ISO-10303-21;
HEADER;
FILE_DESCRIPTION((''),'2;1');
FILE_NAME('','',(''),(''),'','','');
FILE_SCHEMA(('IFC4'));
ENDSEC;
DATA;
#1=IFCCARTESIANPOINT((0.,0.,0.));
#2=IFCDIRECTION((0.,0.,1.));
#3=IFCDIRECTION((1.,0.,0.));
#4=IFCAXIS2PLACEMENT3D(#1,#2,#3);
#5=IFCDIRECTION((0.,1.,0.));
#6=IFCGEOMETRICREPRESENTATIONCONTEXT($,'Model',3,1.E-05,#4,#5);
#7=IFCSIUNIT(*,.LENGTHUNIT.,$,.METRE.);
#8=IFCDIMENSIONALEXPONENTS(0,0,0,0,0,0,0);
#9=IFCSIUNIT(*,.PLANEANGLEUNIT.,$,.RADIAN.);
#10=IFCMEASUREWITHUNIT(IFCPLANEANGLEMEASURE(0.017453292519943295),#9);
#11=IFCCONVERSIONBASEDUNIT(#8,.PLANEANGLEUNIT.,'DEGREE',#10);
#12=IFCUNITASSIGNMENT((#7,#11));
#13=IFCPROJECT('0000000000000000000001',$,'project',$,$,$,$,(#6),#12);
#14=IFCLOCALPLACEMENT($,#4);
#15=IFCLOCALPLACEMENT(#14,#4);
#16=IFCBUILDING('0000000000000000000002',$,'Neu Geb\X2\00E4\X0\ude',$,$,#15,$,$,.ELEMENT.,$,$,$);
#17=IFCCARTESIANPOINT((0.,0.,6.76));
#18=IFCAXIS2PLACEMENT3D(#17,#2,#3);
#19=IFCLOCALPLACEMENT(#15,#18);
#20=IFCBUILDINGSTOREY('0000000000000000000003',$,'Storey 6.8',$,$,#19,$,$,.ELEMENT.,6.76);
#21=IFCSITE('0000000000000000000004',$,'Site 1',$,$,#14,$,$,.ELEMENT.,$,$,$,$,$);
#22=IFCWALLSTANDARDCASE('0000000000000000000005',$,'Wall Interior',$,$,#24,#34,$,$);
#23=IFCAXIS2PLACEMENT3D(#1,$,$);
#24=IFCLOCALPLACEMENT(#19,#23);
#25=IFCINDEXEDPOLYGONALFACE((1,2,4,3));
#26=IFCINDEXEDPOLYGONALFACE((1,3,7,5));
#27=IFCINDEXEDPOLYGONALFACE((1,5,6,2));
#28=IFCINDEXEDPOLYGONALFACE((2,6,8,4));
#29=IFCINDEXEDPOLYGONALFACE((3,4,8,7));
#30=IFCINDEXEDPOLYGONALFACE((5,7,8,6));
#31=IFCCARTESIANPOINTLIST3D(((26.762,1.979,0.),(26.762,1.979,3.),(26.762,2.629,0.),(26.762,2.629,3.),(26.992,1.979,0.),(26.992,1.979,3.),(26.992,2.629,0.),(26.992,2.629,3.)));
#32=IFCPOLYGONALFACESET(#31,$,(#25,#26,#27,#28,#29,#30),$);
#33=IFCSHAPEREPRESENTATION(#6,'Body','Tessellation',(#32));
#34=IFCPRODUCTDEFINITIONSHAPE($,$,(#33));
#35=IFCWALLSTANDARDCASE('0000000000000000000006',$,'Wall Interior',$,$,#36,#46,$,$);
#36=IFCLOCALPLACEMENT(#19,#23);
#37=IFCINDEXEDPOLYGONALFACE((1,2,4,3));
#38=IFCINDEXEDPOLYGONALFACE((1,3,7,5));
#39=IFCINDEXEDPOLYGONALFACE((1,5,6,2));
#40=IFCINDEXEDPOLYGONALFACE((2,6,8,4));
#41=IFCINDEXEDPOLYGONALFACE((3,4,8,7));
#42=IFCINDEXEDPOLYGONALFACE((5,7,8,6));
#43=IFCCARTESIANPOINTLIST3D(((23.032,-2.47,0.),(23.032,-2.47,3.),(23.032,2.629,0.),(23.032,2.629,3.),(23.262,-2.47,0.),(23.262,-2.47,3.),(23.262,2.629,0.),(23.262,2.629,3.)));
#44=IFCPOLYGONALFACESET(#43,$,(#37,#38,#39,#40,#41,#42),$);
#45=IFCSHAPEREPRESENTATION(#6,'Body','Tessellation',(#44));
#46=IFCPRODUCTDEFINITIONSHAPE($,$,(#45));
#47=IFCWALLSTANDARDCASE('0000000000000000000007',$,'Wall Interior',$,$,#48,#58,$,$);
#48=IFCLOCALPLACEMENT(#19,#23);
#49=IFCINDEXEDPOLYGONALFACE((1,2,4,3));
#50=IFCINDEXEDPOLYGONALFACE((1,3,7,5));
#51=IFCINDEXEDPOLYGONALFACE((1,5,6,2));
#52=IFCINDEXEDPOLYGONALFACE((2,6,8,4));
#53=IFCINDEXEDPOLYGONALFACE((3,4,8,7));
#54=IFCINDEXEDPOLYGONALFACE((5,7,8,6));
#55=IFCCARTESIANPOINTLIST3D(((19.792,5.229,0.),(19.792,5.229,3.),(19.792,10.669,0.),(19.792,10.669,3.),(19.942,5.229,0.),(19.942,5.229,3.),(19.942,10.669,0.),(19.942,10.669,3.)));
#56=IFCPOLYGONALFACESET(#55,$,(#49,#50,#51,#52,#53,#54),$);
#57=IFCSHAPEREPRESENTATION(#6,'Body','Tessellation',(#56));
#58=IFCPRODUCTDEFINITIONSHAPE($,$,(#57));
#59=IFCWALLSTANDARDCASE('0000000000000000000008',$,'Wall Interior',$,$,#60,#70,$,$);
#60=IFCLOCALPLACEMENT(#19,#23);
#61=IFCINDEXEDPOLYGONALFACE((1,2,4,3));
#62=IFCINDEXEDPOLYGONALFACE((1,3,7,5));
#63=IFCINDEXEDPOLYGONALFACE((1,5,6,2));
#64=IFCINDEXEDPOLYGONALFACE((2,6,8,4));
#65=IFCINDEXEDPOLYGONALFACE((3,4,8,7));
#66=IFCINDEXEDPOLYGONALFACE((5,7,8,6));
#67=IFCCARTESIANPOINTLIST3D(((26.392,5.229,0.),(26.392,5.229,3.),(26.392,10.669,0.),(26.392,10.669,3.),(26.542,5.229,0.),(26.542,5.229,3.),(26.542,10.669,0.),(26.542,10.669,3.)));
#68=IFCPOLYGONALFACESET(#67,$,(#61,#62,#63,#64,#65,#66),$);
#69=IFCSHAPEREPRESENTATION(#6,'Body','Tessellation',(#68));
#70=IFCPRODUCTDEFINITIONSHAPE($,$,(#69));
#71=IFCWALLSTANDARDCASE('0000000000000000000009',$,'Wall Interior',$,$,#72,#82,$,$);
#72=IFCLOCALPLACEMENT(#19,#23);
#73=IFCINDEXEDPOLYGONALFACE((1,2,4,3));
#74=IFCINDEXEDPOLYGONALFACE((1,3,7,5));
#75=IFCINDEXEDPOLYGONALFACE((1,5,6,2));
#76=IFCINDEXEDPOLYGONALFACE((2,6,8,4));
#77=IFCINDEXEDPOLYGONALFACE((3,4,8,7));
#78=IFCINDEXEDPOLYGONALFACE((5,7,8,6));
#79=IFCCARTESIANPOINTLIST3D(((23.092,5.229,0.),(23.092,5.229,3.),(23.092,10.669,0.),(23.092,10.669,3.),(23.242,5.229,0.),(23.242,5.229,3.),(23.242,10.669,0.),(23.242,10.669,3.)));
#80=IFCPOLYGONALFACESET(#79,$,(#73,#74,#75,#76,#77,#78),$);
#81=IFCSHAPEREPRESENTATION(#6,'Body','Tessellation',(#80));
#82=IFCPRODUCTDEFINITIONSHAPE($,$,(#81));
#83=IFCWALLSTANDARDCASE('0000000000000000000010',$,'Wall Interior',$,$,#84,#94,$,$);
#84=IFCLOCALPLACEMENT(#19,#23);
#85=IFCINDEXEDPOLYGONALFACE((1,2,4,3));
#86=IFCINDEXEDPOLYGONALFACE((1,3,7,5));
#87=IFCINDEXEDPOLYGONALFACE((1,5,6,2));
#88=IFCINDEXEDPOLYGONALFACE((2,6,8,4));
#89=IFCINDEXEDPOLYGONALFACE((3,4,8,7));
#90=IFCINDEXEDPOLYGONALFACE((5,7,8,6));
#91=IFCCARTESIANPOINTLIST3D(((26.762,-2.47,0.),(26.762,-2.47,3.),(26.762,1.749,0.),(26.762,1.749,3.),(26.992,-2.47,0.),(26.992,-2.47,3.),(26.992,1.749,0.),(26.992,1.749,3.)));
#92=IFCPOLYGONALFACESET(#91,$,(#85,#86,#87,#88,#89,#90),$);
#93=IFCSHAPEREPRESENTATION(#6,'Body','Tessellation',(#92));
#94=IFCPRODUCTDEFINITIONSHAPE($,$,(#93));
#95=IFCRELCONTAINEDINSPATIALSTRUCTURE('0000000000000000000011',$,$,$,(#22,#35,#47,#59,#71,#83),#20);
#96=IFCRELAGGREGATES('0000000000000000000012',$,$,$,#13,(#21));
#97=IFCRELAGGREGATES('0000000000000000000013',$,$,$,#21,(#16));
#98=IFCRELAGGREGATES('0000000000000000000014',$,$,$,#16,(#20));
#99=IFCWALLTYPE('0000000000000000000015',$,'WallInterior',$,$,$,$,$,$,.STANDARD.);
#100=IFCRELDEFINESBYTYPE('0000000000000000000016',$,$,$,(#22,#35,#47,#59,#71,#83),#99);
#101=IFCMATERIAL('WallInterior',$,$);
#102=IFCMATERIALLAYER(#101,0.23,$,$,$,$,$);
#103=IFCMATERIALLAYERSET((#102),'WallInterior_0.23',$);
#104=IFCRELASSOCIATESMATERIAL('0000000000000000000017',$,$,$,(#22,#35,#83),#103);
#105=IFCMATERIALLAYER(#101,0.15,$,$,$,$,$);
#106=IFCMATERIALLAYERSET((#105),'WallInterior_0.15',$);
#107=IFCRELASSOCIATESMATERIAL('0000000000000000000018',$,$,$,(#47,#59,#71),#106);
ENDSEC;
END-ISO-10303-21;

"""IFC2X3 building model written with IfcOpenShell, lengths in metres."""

from ifc_helpers import new_model, entity, si_unit, converted_unit, direction, frame, origin_with_axes, place, context, project, spatial, polyline, outline, extrude, material, layer, layer_set, layer_usage, type_object, element, save


model = new_model("IFC2X3")

# Units and contexts
model_context = context("Model", 3, precision=1e-05, world=origin_with_axes(), true_north=direction((0.0, 1.0, 0.0)))
ifc_project = project(units=[si_unit("LENGTHUNIT", "METRE"), converted_unit("PLANEANGLEUNIT", "DEGREE", entity("IfcPlaneAngleMeasure", 0.017453292519943295), si_unit("PLANEANGLEUNIT", "RADIAN"), dimensions=[0, 0, 0, 0, 0, 0, 0])], contexts=[model_context])

# Site, building, storey
site_placement = place(None, origin_with_axes())
site = spatial("IfcSite", under=ifc_project, at=site_placement, Name="Site 1", CompositionType="ELEMENT")
building_placement = place(site_placement, origin_with_axes())
building = spatial("IfcBuilding", under=site, at=building_placement, Name="Neu Gebäude", CompositionType="ELEMENT")
storey_placement = place(building_placement, frame((0.0, 0.0, 6.76), z_axis=(0.0, 0.0, 1.0), x_axis=(1.0, 0.0, 0.0)))
storey = spatial("IfcBuildingStorey", under=building, at=storey_placement, Name="Storey 6.8", CompositionType="ELEMENT", Elevation=6.76)

# Walls
ifc_material_1 = material(Name="WallInterior")
ifc_layer_1 = layer(ifc_material_1, 0.23)
ifc_layer_set_1 = layer_set([ifc_layer_1], Name="WallInterior_0.23")
ifc_layer_usage_1 = layer_usage(ifc_layer_set_1, "AXIS2", "POSITIVE", -0.115)
wall_type_1 = type_object("IfcWallType", Name="WallInterior", PredefinedType="STANDARD")
wall_1_placement = place(storey_placement, frame((26.877, 1.979, 0.0), z_axis=(0.0, 0.0, 1.0), x_axis=(0.0, 1.0, 0.0)))
element("IfcWallStandardCase", 1, at=wall_1_placement, inside=storey, type_object=wall_type_1, material=ifc_layer_usage_1, Name="Wall Interior", context=model_context, shape_type="SweptSolid", body=[
    extrude(outline(polyline([(0.65, -0.115), (0.65, 0.115), (0.0, 0.115), (0.0, -0.115), (0.65, -0.115)])), origin_with_axes(), (0.0, 0.0, 1.0), 3.0),
])
wall_2_placement = place(storey_placement, frame((23.147, -2.47, 0.0), z_axis=(0.0, 0.0, 1.0), x_axis=(0.0, 1.0, 0.0)))
element("IfcWallStandardCase", 2, at=wall_2_placement, inside=storey, type_object=wall_type_1, material=ifc_layer_usage_1, Name="Wall Interior", context=model_context, shape_type="SweptSolid", body=[
    extrude(outline(polyline([(5.099, -0.115), (5.099, 0.115), (0.0, 0.115), (0.0, -0.115), (5.099, -0.115)])), origin_with_axes(), (0.0, 0.0, 1.0), 3.0),
])
ifc_layer_2 = layer(ifc_material_1, 0.15)
ifc_layer_set_2 = layer_set([ifc_layer_2], Name="WallInterior_0.15")
ifc_layer_usage_2 = layer_usage(ifc_layer_set_2, "AXIS2", "POSITIVE", -0.075)
wall_3_placement = place(storey_placement, frame((19.867, 5.229, 0.0), z_axis=(0.0, 0.0, 1.0), x_axis=(0.0, 1.0, 0.0)))
element("IfcWallStandardCase", 3, at=wall_3_placement, inside=storey, type_object=wall_type_1, material=ifc_layer_usage_2, Name="Wall Interior", context=model_context, shape_type="SweptSolid", body=[
    extrude(outline(polyline([(5.44, -0.075), (5.44, 0.075), (0.0, 0.075), (0.0, -0.075), (5.44, -0.075)])), origin_with_axes(), (0.0, 0.0, 1.0), 3.0),
])

# Walls
for number, where, z_axis, x_axis, name in (
    (4, (26.467, 5.229, 0.0), (0.0, 0.0, 1.0), (0.0, 1.0, 0.0), "Wall Interior"),
    (5, (23.167, 5.229, 0.0), (0.0, 0.0, 1.0), (0.0, 1.0, 0.0), "Wall Interior"),
):
    element("IfcWallStandardCase", number, at=place(storey_placement, frame(where, z_axis=z_axis, x_axis=x_axis)), inside=storey, type_object=wall_type_1, material=ifc_layer_usage_2, Name=name, context=model_context, shape_type="SweptSolid", body=[
        extrude(outline(polyline([(5.44, -0.075), (5.44, 0.075), (0.0, 0.075), (0.0, -0.075), (5.44, -0.075)])), origin_with_axes(), (0.0, 0.0, 1.0), 3.0),
    ])
wall_4_placement = place(storey_placement, frame((26.877, -2.47, 0.0), z_axis=(0.0, 0.0, 1.0), x_axis=(0.0, 1.0, 0.0)))
element("IfcWallStandardCase", 6, at=wall_4_placement, inside=storey, type_object=wall_type_1, material=ifc_layer_usage_1, Name="Wall Interior", context=model_context, shape_type="SweptSolid", body=[
    extrude(outline(polyline([(4.219, -0.115), (4.219, 0.115), (0.0, 0.115), (0.0, -0.115), (4.219, -0.115)])), origin_with_axes(), (0.0, 0.0, 1.0), 3.0),
])

save(model, "model.ifc")
